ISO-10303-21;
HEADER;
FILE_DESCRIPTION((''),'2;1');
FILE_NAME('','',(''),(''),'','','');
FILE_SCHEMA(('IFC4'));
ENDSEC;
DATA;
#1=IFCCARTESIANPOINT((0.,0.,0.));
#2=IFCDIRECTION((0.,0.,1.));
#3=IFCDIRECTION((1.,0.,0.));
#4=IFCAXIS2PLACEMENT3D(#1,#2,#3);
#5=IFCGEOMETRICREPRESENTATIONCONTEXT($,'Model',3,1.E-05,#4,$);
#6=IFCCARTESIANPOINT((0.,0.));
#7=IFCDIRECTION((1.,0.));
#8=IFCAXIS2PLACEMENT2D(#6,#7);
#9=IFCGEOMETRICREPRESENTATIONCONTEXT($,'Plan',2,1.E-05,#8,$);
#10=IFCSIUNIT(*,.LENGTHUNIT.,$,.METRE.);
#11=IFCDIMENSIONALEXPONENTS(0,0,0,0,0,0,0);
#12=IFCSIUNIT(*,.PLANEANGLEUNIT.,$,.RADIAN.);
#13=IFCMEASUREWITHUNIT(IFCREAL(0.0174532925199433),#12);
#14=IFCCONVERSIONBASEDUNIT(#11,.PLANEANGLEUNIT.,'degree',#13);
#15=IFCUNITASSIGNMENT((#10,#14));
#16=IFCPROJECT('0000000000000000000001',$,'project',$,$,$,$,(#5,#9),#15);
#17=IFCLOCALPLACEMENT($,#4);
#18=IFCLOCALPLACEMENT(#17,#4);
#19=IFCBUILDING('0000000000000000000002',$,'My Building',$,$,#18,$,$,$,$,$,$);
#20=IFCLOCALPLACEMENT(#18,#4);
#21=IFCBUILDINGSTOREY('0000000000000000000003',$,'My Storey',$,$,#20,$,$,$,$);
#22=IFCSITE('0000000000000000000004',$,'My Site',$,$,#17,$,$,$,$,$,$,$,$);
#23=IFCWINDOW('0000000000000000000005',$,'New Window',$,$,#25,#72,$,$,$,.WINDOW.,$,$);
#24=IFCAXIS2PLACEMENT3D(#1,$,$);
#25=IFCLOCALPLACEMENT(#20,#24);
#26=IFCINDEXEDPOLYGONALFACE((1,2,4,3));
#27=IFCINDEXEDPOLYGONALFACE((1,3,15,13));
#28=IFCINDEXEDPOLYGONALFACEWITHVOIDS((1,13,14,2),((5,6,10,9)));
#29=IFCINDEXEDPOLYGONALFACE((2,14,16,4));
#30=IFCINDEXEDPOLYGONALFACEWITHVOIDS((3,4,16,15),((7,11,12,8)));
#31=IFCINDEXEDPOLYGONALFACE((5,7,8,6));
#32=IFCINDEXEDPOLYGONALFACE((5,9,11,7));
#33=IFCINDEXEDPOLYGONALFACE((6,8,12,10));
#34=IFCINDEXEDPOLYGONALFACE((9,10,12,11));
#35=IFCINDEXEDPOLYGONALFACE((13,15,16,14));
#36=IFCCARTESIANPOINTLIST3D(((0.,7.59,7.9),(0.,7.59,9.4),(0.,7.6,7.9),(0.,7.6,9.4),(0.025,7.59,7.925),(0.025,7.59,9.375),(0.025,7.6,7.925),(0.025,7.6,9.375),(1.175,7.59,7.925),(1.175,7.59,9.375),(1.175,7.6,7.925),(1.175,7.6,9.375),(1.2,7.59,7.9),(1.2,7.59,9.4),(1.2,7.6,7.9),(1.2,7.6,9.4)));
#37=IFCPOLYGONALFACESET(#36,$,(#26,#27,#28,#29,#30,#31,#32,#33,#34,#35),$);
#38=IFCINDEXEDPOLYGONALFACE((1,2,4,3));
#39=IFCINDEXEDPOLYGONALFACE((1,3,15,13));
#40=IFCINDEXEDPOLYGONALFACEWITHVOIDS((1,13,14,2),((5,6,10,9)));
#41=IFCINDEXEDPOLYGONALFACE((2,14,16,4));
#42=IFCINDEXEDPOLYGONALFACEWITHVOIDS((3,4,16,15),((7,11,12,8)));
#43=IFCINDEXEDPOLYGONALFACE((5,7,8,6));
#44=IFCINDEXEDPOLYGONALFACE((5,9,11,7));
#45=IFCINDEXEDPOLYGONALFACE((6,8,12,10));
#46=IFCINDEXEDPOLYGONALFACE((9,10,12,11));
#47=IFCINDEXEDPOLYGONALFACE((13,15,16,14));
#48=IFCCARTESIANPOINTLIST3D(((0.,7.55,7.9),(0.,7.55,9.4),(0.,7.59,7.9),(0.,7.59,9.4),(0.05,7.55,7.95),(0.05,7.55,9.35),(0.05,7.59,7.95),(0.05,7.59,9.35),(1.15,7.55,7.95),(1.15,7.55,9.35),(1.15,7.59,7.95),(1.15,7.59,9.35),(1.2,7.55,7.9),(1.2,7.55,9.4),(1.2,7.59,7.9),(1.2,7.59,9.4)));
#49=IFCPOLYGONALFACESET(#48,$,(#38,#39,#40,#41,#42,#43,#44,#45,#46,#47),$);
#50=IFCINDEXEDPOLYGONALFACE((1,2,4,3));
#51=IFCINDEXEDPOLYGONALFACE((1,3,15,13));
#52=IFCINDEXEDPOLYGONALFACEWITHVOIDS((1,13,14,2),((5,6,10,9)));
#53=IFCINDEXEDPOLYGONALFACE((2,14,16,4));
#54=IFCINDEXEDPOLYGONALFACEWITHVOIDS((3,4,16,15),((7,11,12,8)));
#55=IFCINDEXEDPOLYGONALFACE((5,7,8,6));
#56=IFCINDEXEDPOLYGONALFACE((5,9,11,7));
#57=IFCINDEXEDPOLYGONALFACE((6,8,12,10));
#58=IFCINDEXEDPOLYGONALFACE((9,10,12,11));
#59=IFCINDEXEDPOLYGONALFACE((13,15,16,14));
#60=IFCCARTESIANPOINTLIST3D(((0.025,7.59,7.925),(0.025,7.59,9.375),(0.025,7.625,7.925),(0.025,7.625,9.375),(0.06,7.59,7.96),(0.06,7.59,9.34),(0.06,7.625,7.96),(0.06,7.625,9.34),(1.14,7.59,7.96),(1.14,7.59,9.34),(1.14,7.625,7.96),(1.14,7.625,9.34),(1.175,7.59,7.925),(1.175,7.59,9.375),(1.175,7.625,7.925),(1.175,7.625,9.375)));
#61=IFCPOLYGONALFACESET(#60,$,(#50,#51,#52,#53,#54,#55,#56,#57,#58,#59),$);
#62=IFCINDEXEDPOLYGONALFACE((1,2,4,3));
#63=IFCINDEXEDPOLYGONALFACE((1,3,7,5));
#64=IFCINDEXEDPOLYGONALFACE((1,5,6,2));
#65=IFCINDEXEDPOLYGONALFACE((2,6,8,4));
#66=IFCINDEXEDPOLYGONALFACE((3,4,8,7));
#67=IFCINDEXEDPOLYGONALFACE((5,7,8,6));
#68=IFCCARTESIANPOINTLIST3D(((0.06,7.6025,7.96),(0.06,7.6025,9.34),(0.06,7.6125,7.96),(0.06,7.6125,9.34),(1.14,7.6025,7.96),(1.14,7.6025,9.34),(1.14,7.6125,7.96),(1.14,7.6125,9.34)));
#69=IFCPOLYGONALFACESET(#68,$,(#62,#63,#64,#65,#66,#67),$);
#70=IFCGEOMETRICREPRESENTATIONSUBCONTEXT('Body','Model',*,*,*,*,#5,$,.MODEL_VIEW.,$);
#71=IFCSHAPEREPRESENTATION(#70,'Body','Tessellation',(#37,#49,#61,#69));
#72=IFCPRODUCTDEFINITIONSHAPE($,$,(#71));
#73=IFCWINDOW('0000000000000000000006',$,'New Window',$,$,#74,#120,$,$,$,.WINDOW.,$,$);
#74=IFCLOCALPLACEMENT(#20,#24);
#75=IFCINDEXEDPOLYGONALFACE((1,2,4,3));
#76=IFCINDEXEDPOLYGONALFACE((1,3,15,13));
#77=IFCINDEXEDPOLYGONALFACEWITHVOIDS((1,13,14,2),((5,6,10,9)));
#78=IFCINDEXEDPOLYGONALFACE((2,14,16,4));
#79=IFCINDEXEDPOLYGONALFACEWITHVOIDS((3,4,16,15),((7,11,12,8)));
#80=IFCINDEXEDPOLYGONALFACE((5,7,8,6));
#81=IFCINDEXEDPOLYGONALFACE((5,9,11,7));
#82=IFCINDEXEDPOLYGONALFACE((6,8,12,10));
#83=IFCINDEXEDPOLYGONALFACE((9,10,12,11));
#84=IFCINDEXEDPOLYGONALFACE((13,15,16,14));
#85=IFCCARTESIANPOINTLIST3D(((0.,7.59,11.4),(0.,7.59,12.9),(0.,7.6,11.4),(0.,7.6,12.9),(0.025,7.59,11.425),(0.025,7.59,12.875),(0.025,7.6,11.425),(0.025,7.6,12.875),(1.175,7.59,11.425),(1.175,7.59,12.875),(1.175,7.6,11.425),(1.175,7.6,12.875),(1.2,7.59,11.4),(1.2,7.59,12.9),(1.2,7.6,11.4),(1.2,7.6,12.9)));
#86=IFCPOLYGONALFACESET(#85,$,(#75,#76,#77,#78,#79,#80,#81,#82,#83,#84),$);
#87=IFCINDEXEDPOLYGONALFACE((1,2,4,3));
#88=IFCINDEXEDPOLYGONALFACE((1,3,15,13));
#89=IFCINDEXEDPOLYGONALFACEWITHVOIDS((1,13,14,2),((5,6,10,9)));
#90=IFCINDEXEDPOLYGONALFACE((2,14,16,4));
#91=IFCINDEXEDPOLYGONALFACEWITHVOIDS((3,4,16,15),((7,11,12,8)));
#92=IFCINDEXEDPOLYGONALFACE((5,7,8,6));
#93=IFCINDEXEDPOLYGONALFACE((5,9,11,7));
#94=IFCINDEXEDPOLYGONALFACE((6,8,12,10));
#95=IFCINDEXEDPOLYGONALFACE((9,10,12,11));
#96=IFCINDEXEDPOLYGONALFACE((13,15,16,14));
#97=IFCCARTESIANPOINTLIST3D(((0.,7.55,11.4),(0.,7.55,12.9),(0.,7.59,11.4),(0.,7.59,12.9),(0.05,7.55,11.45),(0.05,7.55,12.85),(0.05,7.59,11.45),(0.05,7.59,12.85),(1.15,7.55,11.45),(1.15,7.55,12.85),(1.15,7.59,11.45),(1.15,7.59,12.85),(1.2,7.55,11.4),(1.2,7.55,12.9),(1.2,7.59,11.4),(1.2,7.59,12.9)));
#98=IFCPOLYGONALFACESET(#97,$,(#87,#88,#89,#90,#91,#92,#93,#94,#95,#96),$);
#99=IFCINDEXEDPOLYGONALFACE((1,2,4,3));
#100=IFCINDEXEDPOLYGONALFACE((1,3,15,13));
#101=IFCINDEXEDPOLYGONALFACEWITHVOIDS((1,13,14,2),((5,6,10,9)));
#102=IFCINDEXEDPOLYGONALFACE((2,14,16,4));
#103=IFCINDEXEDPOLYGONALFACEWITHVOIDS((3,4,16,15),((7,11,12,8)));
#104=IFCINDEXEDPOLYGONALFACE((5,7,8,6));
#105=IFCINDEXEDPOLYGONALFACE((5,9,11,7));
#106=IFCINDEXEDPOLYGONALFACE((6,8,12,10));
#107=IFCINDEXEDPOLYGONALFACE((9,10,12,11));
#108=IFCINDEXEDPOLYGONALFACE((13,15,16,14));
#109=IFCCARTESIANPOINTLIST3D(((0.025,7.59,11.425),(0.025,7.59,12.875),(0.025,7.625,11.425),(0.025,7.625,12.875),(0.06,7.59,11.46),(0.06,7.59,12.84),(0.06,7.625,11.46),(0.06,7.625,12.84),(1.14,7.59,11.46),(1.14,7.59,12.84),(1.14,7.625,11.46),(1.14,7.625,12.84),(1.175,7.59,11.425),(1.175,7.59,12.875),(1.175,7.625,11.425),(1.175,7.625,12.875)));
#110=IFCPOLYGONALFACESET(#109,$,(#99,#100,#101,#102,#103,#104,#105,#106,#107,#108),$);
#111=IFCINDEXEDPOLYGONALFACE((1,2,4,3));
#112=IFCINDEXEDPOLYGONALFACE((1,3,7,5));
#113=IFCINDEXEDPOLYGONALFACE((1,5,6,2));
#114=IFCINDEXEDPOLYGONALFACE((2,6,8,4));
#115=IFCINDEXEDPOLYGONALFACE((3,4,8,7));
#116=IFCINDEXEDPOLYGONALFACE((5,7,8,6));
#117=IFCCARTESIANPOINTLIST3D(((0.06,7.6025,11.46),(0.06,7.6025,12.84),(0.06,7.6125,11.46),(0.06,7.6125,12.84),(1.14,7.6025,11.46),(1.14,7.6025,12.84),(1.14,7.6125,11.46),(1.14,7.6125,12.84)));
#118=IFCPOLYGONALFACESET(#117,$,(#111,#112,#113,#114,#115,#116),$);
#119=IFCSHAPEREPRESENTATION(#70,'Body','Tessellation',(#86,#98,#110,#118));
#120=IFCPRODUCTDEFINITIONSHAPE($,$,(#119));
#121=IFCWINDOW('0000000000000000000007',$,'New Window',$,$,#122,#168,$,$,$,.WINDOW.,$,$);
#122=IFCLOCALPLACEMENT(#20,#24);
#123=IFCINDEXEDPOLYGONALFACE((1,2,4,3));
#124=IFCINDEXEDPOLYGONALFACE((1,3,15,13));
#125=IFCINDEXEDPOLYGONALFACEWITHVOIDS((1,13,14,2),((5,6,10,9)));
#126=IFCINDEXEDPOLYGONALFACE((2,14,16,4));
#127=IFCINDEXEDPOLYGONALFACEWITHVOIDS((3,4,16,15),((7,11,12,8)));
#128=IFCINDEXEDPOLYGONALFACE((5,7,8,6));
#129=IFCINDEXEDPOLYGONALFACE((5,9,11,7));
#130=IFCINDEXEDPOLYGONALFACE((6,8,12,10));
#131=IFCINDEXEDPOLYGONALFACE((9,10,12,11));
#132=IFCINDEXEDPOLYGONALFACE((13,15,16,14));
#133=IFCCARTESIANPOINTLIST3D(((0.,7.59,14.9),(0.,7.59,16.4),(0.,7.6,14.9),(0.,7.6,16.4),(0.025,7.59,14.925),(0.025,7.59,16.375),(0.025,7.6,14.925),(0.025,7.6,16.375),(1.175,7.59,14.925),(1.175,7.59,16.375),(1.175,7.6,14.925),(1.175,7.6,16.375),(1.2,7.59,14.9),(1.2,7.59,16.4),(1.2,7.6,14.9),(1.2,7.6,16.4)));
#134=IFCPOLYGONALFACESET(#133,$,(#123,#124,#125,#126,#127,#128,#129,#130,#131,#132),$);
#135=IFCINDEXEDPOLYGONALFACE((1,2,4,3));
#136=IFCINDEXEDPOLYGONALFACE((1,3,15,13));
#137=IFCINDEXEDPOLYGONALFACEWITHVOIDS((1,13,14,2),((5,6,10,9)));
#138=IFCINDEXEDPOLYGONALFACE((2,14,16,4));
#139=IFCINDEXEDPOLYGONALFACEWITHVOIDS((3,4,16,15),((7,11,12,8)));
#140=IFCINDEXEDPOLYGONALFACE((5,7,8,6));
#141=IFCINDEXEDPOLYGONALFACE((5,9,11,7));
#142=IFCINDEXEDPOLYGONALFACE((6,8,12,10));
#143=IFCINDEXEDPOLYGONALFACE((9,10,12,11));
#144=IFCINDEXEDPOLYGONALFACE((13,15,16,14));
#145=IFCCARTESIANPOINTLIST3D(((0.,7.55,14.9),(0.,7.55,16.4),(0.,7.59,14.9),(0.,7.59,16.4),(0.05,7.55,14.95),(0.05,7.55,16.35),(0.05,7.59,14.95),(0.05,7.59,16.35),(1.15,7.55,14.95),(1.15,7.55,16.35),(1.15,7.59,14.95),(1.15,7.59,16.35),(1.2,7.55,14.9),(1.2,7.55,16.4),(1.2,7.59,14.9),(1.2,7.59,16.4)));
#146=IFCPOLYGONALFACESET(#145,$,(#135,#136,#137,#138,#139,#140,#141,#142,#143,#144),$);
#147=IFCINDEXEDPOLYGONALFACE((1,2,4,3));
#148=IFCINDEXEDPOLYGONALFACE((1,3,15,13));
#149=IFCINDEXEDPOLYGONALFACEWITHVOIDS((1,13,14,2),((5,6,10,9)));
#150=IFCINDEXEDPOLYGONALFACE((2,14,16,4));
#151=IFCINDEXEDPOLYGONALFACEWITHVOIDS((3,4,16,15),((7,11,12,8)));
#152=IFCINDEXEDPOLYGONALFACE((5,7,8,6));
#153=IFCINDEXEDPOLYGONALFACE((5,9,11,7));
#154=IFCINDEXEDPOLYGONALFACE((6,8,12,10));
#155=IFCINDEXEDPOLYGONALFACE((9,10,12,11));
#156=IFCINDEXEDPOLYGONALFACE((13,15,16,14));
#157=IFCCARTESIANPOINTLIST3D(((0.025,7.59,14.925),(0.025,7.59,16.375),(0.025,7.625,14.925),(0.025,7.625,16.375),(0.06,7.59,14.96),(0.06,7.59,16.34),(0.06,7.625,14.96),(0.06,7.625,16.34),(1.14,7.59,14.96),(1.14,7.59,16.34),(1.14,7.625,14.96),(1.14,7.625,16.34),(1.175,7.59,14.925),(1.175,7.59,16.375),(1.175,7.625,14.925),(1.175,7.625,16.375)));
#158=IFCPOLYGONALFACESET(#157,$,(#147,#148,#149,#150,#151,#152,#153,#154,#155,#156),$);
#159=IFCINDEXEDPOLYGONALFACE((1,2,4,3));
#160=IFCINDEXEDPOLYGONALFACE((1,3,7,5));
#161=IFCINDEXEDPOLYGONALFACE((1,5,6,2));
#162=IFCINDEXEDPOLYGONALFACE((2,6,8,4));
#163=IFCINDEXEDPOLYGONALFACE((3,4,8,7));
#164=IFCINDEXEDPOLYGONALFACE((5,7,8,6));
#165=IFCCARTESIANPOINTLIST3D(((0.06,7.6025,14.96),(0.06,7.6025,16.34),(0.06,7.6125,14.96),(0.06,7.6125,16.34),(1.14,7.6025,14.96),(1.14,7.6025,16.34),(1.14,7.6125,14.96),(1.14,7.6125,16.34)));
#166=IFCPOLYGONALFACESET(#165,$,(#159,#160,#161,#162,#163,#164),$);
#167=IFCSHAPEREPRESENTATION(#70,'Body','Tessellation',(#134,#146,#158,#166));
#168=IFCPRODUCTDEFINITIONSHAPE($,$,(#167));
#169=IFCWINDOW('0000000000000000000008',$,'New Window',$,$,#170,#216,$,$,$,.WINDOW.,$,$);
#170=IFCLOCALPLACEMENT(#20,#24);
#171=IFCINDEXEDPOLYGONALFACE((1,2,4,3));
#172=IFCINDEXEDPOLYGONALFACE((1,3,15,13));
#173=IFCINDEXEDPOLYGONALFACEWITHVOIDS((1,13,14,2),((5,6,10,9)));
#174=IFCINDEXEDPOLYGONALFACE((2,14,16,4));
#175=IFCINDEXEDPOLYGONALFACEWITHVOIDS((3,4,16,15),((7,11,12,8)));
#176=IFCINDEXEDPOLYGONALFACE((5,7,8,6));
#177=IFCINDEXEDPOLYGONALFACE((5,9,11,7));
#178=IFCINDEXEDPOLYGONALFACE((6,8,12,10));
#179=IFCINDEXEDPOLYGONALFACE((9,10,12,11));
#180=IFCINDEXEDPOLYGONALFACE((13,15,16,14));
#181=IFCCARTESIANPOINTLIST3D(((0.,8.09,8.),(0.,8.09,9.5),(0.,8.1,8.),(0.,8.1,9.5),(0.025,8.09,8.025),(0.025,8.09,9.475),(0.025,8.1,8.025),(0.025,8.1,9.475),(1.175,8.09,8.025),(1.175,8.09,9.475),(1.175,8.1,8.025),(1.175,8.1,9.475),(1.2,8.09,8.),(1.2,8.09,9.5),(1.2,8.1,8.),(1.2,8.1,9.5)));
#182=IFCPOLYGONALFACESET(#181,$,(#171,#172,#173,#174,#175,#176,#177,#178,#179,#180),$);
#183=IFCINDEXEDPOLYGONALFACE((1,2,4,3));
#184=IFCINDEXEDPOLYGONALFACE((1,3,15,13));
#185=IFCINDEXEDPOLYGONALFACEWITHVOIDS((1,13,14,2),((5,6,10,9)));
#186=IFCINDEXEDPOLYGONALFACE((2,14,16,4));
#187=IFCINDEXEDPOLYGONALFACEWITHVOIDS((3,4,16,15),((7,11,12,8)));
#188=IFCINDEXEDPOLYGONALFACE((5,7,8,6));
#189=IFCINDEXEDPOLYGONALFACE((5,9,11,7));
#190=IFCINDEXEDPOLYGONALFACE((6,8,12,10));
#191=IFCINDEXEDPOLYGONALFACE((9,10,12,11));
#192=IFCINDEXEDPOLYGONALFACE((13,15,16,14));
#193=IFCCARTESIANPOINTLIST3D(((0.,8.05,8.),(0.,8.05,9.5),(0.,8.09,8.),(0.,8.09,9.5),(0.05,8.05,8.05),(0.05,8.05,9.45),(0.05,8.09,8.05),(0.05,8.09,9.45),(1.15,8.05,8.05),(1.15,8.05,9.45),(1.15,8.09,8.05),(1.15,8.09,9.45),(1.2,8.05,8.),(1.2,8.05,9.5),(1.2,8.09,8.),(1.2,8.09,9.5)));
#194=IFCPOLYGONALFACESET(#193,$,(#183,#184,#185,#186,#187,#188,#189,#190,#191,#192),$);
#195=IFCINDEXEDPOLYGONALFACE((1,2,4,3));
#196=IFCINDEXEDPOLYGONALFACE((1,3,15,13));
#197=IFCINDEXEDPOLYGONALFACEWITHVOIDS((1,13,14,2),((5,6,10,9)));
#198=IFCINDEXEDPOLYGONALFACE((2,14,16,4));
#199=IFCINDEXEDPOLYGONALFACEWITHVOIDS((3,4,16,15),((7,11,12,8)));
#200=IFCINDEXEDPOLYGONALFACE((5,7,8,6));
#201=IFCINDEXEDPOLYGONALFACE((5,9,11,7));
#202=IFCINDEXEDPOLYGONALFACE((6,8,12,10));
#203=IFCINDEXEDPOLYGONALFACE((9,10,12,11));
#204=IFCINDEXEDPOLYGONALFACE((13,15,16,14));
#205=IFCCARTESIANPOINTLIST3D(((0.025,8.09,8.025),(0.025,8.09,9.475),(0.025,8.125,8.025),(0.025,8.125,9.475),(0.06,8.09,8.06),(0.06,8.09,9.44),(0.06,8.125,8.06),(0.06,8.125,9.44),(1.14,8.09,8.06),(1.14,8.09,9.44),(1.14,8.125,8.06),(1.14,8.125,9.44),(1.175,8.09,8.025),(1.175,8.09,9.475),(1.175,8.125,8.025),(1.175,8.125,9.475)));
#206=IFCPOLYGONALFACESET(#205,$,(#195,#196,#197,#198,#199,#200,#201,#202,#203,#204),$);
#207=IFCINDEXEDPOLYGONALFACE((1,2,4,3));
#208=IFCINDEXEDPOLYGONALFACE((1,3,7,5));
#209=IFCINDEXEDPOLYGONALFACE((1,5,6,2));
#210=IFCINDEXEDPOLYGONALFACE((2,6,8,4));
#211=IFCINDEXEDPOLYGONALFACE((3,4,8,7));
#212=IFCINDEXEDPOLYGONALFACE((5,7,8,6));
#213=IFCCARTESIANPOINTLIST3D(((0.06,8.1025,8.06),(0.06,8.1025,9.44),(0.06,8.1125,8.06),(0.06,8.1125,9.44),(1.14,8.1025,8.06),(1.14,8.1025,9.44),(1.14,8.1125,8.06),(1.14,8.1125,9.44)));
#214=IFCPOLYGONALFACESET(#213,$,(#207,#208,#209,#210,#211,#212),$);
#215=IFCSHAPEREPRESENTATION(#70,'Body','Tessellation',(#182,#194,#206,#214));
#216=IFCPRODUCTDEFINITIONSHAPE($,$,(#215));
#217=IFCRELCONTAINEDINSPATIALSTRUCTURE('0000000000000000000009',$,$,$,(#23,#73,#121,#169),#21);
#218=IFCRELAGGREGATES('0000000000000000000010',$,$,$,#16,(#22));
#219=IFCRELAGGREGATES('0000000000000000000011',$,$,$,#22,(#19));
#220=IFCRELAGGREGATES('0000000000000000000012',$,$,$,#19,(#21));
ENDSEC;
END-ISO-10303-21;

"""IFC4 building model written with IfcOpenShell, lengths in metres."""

from ifc_helpers import new_model, entity, si_unit, converted_unit, frame, origin_with_axes, origin_2d_with_axis, place, context, subcontext, project, spatial, line, indexed_curve, outline, extrude, element, save


model = new_model("IFC4")

# Units and contexts
model_context = context("Model", 3, precision=1e-05, world=origin_with_axes())
plan_context = context("Plan", 2, precision=1e-05, world=origin_2d_with_axis())
body_context = subcontext(model_context, "Body", "Model", "MODEL_VIEW")
ifc_project = project(units=[si_unit("LENGTHUNIT", "METRE"), converted_unit("PLANEANGLEUNIT", "degree", entity("IfcReal", 0.0174532925199433), si_unit("PLANEANGLEUNIT", "RADIAN"), dimensions=[0, 0, 0, 0, 0, 0, 0])], contexts=[model_context, plan_context])

# Site, building, storey
site_placement = place(None, origin_with_axes())
site = spatial("IfcSite", under=ifc_project, at=site_placement, Name="My Site")
building_placement = place(site_placement, origin_with_axes())
building = spatial("IfcBuilding", under=site, at=building_placement, Name="My Building")
storey_placement = place(building_placement, origin_with_axes())
storey = spatial("IfcBuildingStorey", under=building, at=storey_placement, Name="My Storey")

# Windows
for number, where, z_axis, x_axis, name in (
    (1, (0.0, 7.5, 7.9), (0.0, 0.0, 1.0), (1.0, 0.0, 0.0), "New Window"),
    (2, (0.0, 7.5, 11.4), (0.0, 0.0, 1.0), (1.0, 0.0, 0.0), "New Window"),
    (3, (0.0, 7.5, 14.9), (0.0, 0.0, 1.0), (1.0, 0.0, 0.0), "New Window"),
    (4, (0.0, 8.0, 8.0), (0.0, 0.0, 1.0), (1.0, 0.0, 0.0), "New Window"),
):
    element("IfcWindow", number, at=place(storey_placement, frame(where, z_axis=z_axis, x_axis=x_axis)), inside=storey, Name=name, PredefinedType="WINDOW", context=body_context, shape_type="SweptSolid", body=[
        extrude(outline(indexed_curve([(0.0, 0.0), (1.2, 0.0), (1.2, 1.5), (0.0, 1.5)], segments=[line(1, 2, 3, 4, 1)]), holes=[indexed_curve([(0.025, 0.025), (1.175, 0.025), (1.175, 1.475), (0.025, 1.475)], segments=[line(1, 2, 3, 4, 1)])]), frame((0.0, 0.09, 0.0), z_axis=(0.0, -1.0, 0.0), x_axis=(1.0, 0.0, 0.0)), (0.0, 0.0, -1.0), 0.01),
        extrude(outline(indexed_curve([(0.0, 0.0), (1.2, 0.0), (1.2, 1.5), (0.0, 1.5)], segments=[line(1, 2, 3, 4, 1)]), holes=[indexed_curve([(0.05, 0.05), (1.15, 0.05), (1.15, 1.45), (0.05, 1.45)], segments=[line(1, 2, 3, 4, 1)])]), frame((0.0, 0.05, 0.0), z_axis=(0.0, -1.0, 0.0), x_axis=(1.0, 0.0, 0.0)), (0.0, 0.0, -1.0), 0.04),
        extrude(outline(indexed_curve([(0.0, 0.0), (1.15, 0.0), (1.15, 1.45), (0.0, 1.45)], segments=[line(1, 2, 3, 4, 1)]), holes=[indexed_curve([(0.035, 0.035), (1.115, 0.035), (1.115, 1.415), (0.035, 1.415)], segments=[line(1, 2, 3, 4, 1)])]), frame((0.025, 0.09, 0.025), z_axis=(0.0, -1.0, 0.0), x_axis=(1.0, 0.0, 0.0)), (0.0, 0.0, -1.0), 0.035),
        extrude(outline(indexed_curve([(0.035, 0.035), (1.115, 0.035), (1.115, 1.415), (0.035, 1.415)], segments=[line(1, 2, 3, 4, 1)])), frame((0.025, 0.1025, 0.025), z_axis=(0.0, -1.0, 0.0), x_axis=(1.0, 0.0, 0.0)), (0.0, 0.0, -1.0), 0.01),
    ])

save(model, "model.ifc")
